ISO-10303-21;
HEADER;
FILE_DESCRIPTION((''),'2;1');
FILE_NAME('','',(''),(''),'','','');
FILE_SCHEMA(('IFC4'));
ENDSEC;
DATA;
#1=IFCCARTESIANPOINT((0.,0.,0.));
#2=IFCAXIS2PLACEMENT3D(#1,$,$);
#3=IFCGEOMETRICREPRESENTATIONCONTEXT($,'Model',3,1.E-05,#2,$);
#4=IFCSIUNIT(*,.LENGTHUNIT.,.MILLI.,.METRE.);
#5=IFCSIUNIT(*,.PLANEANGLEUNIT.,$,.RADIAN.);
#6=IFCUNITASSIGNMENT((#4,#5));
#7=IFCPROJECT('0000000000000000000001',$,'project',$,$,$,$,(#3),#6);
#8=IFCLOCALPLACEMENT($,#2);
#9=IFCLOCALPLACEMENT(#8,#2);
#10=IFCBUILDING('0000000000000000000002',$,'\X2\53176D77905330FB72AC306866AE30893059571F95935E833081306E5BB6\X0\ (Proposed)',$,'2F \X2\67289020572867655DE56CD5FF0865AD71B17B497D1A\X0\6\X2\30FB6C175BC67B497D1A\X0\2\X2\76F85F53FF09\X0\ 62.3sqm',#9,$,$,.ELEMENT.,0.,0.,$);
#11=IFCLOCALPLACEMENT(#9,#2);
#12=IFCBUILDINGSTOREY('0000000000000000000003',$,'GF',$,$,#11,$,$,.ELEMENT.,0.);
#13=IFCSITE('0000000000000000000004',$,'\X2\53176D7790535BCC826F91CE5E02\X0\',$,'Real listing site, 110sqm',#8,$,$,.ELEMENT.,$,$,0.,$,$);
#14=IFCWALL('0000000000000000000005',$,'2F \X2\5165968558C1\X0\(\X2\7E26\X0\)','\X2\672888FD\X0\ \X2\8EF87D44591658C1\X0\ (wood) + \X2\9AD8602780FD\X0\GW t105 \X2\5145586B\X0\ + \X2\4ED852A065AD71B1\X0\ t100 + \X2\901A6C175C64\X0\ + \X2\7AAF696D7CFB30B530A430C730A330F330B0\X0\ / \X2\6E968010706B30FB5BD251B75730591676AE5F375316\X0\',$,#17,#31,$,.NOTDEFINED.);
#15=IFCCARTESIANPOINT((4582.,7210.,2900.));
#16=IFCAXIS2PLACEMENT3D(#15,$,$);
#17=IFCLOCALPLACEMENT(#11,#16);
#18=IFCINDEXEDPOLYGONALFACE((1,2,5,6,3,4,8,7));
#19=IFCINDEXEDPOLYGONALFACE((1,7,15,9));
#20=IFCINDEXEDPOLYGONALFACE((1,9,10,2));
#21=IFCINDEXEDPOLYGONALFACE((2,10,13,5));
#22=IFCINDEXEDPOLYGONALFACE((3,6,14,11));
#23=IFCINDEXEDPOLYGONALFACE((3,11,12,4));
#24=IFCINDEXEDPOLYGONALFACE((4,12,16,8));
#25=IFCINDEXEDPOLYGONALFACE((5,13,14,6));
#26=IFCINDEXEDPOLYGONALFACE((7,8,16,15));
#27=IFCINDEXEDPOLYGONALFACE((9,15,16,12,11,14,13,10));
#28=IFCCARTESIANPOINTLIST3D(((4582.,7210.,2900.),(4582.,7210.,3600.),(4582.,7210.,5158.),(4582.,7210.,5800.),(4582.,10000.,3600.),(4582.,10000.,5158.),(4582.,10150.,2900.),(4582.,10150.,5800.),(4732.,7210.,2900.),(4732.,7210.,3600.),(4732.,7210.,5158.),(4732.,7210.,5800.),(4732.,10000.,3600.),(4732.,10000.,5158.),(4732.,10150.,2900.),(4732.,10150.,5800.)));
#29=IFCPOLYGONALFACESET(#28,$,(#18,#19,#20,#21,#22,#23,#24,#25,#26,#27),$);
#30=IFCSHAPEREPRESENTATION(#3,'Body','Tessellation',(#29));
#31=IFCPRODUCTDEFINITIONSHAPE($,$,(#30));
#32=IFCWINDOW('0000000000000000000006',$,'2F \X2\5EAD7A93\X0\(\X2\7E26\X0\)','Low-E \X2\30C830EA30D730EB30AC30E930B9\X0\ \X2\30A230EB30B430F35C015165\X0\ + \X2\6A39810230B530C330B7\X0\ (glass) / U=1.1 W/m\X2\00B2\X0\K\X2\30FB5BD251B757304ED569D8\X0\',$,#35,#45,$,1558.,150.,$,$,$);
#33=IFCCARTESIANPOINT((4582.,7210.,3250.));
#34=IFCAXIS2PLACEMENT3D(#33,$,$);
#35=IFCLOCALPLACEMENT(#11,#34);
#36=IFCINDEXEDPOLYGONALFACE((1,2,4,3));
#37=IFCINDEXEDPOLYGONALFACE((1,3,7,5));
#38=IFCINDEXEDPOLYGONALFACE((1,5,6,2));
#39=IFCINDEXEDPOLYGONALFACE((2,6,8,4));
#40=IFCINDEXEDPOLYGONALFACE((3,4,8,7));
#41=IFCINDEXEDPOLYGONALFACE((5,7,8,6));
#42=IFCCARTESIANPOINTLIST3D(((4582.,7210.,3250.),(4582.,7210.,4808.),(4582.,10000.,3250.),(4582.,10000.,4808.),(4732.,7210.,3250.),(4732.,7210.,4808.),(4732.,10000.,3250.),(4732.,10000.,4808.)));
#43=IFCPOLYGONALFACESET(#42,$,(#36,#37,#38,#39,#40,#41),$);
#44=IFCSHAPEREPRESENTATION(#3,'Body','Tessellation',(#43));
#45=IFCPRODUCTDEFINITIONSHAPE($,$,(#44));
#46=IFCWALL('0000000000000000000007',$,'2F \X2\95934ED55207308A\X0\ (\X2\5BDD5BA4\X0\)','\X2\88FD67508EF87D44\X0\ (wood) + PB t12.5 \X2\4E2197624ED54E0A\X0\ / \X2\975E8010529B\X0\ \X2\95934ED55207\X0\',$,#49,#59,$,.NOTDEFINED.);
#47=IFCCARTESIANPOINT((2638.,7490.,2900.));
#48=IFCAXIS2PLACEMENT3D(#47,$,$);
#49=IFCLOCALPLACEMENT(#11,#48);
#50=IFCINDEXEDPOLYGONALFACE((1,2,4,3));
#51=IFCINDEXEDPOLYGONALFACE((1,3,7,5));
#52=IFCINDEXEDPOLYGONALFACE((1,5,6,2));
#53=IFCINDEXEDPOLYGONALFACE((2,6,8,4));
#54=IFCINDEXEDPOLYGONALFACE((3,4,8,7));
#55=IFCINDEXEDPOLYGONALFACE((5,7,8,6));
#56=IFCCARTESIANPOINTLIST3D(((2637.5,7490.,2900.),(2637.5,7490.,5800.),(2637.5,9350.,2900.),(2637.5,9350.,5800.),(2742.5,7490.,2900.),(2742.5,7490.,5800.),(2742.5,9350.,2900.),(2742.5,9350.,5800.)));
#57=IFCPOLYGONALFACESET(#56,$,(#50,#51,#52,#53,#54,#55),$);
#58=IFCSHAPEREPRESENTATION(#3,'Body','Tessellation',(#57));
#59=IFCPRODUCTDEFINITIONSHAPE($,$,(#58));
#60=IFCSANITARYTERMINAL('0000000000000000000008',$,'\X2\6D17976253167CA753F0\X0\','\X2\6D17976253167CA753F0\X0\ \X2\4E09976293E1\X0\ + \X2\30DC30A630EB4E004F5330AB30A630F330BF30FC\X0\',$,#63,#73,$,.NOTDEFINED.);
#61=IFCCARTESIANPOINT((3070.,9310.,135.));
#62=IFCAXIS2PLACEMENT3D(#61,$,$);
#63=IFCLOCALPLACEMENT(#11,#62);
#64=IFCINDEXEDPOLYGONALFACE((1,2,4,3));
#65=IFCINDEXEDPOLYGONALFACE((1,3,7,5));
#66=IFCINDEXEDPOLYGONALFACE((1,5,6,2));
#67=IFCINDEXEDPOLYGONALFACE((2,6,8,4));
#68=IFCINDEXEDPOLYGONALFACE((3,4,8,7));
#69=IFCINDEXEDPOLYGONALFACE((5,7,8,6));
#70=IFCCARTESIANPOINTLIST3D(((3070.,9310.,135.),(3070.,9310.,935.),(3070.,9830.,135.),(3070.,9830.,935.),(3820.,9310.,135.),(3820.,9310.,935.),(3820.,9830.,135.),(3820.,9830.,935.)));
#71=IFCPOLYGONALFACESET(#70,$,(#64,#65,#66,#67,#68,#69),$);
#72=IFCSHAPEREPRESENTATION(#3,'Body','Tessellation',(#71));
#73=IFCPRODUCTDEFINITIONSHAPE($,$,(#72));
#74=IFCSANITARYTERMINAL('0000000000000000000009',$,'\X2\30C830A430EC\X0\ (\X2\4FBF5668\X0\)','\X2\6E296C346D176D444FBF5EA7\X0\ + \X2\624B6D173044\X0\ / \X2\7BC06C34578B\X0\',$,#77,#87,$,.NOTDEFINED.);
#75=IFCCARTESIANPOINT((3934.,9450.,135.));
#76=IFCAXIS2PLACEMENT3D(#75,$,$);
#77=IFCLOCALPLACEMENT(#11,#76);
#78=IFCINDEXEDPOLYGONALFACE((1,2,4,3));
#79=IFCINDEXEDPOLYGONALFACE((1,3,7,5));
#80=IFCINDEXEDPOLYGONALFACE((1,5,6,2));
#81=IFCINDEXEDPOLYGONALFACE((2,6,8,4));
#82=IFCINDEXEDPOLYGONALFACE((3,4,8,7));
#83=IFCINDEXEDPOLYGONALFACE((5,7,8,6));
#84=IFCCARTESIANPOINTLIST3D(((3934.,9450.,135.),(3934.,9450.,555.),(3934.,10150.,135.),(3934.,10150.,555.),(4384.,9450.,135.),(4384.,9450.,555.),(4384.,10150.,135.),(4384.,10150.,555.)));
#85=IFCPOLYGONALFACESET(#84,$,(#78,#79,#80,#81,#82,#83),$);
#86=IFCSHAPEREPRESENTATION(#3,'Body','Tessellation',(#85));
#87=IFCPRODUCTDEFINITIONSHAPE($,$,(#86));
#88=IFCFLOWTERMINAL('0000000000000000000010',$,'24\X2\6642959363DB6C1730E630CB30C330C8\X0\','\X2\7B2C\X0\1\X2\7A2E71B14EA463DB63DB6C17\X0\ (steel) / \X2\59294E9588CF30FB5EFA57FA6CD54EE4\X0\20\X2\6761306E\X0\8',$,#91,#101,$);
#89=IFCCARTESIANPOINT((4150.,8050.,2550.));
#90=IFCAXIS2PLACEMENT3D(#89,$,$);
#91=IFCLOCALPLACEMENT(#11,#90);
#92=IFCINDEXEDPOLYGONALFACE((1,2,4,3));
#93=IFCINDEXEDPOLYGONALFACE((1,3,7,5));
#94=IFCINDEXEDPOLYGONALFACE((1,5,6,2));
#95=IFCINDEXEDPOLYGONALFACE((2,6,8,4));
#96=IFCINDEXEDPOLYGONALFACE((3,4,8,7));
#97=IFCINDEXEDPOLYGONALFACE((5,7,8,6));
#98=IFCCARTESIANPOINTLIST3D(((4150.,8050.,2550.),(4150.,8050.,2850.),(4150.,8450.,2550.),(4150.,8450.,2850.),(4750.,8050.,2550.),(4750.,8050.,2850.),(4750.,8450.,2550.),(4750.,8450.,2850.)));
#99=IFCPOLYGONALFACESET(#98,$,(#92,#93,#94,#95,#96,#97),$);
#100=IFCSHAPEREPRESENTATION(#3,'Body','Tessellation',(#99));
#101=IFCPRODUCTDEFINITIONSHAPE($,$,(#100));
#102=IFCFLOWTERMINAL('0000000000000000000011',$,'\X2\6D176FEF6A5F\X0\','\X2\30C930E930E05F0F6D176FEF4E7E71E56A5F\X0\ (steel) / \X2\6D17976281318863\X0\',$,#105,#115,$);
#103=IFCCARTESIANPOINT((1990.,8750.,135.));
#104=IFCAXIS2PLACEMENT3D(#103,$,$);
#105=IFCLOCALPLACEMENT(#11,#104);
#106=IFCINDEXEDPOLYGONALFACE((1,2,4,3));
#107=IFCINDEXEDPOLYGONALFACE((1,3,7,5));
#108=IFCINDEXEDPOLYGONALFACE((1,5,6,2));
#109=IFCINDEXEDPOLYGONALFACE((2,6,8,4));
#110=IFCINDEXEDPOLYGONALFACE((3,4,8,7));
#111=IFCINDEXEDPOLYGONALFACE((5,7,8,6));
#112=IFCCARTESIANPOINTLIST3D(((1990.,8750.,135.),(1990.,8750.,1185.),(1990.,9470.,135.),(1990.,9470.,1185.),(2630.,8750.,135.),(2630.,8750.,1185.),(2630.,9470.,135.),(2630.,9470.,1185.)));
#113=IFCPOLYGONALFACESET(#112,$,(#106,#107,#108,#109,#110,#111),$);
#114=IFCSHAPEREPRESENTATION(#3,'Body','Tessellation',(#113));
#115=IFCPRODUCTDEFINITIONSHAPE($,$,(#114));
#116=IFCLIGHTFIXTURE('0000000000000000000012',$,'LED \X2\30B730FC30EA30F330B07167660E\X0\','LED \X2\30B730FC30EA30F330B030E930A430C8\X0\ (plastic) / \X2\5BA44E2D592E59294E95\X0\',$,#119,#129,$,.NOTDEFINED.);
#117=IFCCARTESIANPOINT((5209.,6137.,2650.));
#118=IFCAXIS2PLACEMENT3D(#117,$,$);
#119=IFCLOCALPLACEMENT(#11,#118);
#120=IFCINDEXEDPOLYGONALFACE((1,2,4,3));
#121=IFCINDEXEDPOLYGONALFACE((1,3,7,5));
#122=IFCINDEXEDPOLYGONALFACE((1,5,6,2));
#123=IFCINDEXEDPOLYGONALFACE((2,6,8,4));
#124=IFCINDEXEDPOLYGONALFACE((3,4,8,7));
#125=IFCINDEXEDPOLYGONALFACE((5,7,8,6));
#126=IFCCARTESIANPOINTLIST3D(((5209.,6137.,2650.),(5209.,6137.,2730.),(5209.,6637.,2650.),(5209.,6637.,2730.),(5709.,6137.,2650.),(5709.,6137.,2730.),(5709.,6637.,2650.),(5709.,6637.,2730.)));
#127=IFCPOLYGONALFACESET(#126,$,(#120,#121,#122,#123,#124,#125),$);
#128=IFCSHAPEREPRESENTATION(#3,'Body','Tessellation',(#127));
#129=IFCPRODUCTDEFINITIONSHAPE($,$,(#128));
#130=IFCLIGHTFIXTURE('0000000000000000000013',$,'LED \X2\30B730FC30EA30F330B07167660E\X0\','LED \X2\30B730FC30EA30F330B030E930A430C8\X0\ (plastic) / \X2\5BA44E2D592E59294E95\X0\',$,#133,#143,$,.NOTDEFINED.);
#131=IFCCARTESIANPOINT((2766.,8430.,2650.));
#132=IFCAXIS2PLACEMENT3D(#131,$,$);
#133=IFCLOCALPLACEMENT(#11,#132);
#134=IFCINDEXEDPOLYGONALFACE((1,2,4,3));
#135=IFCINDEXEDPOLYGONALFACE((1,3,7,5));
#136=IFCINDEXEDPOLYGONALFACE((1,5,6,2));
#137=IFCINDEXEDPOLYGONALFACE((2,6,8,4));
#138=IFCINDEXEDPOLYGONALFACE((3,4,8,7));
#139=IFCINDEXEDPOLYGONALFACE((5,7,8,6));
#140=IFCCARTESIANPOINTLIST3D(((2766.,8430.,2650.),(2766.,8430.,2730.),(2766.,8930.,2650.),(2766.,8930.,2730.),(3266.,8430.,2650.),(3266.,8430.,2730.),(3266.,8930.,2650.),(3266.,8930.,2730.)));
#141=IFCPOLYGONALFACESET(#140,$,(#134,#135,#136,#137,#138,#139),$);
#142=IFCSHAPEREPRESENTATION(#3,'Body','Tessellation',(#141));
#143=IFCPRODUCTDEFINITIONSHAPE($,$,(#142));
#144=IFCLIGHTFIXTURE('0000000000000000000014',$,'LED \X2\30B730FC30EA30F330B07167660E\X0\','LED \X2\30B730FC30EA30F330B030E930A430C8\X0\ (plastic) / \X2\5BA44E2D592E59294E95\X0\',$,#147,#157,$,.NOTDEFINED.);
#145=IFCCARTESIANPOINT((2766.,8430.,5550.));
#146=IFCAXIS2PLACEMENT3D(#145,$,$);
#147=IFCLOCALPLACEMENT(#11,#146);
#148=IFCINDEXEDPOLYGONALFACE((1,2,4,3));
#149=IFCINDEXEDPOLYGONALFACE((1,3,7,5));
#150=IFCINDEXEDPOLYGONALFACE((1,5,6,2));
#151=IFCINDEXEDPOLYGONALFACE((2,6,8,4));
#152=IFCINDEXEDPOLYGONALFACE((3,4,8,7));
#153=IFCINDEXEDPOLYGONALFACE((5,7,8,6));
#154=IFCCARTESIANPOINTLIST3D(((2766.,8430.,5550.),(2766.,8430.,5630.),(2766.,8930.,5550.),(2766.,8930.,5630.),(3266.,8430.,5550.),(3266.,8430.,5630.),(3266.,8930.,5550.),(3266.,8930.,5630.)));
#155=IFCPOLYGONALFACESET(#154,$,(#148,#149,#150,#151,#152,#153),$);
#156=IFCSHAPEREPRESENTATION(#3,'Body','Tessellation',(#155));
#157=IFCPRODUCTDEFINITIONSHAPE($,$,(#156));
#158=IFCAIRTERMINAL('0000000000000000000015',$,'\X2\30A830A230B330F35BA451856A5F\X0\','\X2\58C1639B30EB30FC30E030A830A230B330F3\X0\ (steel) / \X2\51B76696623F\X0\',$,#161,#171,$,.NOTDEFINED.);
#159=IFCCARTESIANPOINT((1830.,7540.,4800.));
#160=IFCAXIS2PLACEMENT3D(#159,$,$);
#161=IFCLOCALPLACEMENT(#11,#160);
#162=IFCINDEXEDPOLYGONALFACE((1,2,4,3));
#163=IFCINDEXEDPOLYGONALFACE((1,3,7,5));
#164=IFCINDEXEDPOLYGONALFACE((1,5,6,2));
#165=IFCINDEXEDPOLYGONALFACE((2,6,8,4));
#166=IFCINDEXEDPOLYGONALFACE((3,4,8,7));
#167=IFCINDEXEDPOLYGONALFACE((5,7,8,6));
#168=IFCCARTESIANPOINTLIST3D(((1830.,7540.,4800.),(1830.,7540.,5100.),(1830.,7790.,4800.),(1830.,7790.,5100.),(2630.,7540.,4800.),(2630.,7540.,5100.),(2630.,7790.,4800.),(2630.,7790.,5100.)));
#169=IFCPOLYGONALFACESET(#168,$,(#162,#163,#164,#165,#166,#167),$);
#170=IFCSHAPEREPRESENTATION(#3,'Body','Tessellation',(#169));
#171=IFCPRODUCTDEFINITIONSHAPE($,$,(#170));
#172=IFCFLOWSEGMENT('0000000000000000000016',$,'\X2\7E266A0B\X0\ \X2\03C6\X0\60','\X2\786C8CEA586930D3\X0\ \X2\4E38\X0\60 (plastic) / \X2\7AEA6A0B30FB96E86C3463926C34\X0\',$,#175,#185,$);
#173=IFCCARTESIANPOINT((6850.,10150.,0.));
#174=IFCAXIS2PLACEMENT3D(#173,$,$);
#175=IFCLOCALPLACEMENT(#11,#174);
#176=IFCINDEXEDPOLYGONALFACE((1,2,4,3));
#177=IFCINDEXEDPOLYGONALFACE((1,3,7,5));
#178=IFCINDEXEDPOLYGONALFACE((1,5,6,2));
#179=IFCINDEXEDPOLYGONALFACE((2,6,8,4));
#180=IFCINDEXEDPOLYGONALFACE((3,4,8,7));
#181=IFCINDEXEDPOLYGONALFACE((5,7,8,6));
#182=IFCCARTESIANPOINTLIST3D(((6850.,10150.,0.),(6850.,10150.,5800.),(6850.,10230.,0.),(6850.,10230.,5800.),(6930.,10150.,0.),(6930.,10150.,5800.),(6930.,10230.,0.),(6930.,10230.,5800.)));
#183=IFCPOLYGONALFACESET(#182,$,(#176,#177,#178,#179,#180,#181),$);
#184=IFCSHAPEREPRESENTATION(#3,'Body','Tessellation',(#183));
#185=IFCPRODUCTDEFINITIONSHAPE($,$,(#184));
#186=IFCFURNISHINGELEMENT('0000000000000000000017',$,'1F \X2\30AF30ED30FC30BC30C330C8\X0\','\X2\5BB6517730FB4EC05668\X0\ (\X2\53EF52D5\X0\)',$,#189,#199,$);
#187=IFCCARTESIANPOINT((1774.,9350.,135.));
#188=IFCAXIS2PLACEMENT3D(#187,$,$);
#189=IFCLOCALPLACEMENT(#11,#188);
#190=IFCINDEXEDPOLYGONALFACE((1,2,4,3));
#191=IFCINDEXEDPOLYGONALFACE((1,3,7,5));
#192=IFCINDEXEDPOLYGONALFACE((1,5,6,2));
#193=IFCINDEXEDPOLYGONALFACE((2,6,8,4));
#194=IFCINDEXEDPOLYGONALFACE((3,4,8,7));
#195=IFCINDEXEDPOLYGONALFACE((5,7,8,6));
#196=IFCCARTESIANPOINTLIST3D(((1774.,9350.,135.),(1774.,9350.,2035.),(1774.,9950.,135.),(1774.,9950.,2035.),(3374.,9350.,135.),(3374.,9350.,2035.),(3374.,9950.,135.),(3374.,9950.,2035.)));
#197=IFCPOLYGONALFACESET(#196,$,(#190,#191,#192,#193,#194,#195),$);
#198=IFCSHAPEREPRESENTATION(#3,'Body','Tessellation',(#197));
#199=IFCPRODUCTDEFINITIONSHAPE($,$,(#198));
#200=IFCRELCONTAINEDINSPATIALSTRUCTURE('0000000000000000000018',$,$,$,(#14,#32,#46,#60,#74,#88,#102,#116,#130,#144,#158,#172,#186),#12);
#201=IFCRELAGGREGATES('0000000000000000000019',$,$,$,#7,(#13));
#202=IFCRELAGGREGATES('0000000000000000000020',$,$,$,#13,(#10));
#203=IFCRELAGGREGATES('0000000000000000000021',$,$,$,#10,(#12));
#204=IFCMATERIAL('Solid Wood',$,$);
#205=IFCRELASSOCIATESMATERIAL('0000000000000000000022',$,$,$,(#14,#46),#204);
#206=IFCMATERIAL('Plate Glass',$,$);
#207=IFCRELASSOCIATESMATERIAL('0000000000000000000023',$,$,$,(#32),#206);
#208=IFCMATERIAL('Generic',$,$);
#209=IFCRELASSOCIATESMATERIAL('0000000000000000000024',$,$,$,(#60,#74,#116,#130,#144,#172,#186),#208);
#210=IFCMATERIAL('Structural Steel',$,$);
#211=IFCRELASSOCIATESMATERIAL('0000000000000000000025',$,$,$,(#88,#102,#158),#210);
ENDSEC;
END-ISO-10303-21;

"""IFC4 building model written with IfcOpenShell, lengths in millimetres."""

from ifc_helpers import new_model, si_unit, frame, frame_2d, origin, place, context, project, spatial, rectangle, extrude, material, element, fill, save


model = new_model("IFC4")

# Units and contexts
model_context = context("Model", 3, precision=1e-05, world=origin())
ifc_project = project(units=[si_unit("LENGTHUNIT", "METRE", prefix="MILLI"), si_unit("PLANEANGLEUNIT", "RADIAN")], contexts=[model_context])

# Site, building, storey
site_placement = place(None, origin())
site = spatial("IfcSite", under=ifc_project, at=site_placement, Name="北海道富良野市", ObjectType="Real listing site, 110sqm", CompositionType="ELEMENT", RefElevation=0.0)
building_placement = place(site_placement, origin())
building = spatial("IfcBuilding", under=site, at=building_placement, Name="北海道・犬と暮らす土間広めの家 (Proposed)", ObjectType="2F 木造在来工法（断熱等級6・気密等級2相当） 62.3sqm", CompositionType="ELEMENT", ElevationOfRefHeight=0.0, ElevationOfTerrain=0.0)
storey_placement = place(building_placement, origin())
storey = spatial("IfcBuildingStorey", under=building, at=storey_placement, Name="GF", CompositionType="ELEMENT", Elevation=0.0)

# Shared definitions
ifc_material_1 = material(Name="Solid Wood")

# Shared definitions
ifc_material_2 = material(Name="Plate Glass")

# Wall, opening, window
wall_1_placement = place(storey_placement, frame((4582.0, 7210.0, 2900.0)))
wall_1 = element("IfcWall", 1, at=wall_1_placement, inside=storey, material=ifc_material_1, Name="2F 入隅壁(縦)", Description="木製 軸組外壁 (wood) + 高性能GW t105 充填 + 付加断熱 t100 + 通気層 + 窯業系サイディング / 準耐火・寒冷地外皮強化", PredefinedType="NOTDEFINED", context=model_context, shape_type="SweptSolid", body=[
    extrude(rectangle(XDim=150.0, YDim=2940.0, at=frame_2d((75.0, 1470.0))), frame((4582.0, 7210.0, 2900.0)), (0.0, 0.0, 1.0), 2900.0),
])
opening_1_placement = place(storey_placement, frame((4582.0, 7210.0, 3250.0)))
opening_1 = element("IfcOpeningElement", 2, at=opening_1_placement, cuts=wall_1, PredefinedType="NOTDEFINED", context=model_context, shape_type="SweptSolid", body=[
    extrude(rectangle(XDim=150.0, YDim=2790.0, at=frame_2d((75.0, 1395.0))), frame((4582.0, 7210.0, 3250.0)), (0.0, 0.0, 1.0), 1558.0),
])
window_1_placement = place(storey_placement, frame((4582.0, 7210.0, 3250.0)))
window_1 = element("IfcWindow", 3, at=window_1_placement, inside=storey, material=ifc_material_2, Name="2F 庭窓(縦)", Description="Low-E トリプルガラス アルゴン封入 + 樹脂サッシ (glass) / U=1.1 W/m²K・寒冷地仕様", OverallHeight=1558.0, OverallWidth=150.0, context=model_context, shape_type="SweptSolid", body=[
    extrude(rectangle(XDim=150.0, YDim=2790.0, at=frame_2d((75.0, 1395.0))), frame((4582.0, 7210.0, 3250.0)), (0.0, 0.0, 1.0), 1558.0),
])
fill(opening_1, window_1)

# Wall
wall_2_placement = place(storey_placement, frame((2638.0, 7490.0, 2900.0)))
element("IfcWall", 4, at=wall_2_placement, inside=storey, material=ifc_material_1, Name="2F 間仕切り (寝室)", Description="製材軸組 (wood) + PB t12.5 両面仕上 / 非耐力 間仕切", PredefinedType="NOTDEFINED", context=model_context, shape_type="SweptSolid", body=[
    extrude(rectangle(XDim=105.0, YDim=1860.0, at=frame_2d((52.0, 930.0))), frame((2638.0, 7490.0, 2900.0)), (0.0, 0.0, 1.0), 2900.0),
])

# Sanitary terminals
ifc_material_3 = material(Name="Generic")
sanitary_terminal_1_placement = place(storey_placement, frame((3070.0, 9310.0, 135.0)))
element("IfcSanitaryTerminal", 5, at=sanitary_terminal_1_placement, inside=storey, material=ifc_material_3, Name="洗面化粧台", Description="洗面化粧台 三面鏡 + ボウル一体カウンター", PredefinedType="NOTDEFINED", context=model_context, shape_type="SweptSolid", body=[
    extrude(rectangle(XDim=750.0, YDim=520.0, at=frame_2d((375.0, 260.0))), frame((3070.0, 9310.0, 135.0)), (0.0, 0.0, 1.0), 800.0),
])
sanitary_terminal_2_placement = place(storey_placement, frame((3934.0, 9450.0, 135.0)))
element("IfcSanitaryTerminal", 6, at=sanitary_terminal_2_placement, inside=storey, material=ifc_material_3, Name="トイレ (便器)", Description="温水洗浄便座 + 手洗い / 節水型", PredefinedType="NOTDEFINED", context=model_context, shape_type="SweptSolid", body=[
    extrude(rectangle(XDim=450.0, YDim=700.0, at=frame_2d((225.0, 350.0))), frame((3934.0, 9450.0, 135.0)), (0.0, 0.0, 1.0), 420.0),
])

# Flow terminals
ifc_material_4 = material(Name="Structural Steel")
flow_terminal_1_placement = place(storey_placement, frame((4150.0, 8050.0, 2550.0)))
element("IfcFlowTerminal", 7, at=flow_terminal_1_placement, inside=storey, material=ifc_material_4, Name="24時間換気ユニット", Description="第1種熱交換換気 (steel) / 天井裏・建基法令20条の8", context=model_context, shape_type="SweptSolid", body=[
    extrude(rectangle(XDim=600.0, YDim=400.0, at=frame_2d((300.0, 200.0))), frame((4150.0, 8050.0, 2550.0)), (0.0, 0.0, 1.0), 300.0),
])
flow_terminal_2_placement = place(storey_placement, frame((1990.0, 8750.0, 135.0)))
element("IfcFlowTerminal", 8, at=flow_terminal_2_placement, inside=storey, material=ifc_material_4, Name="洗濯機", Description="ドラム式洗濯乾燥機 (steel) / 洗面脱衣", context=model_context, shape_type="SweptSolid", body=[
    extrude(rectangle(XDim=640.0, YDim=720.0, at=frame_2d((320.0, 360.0))), frame((1990.0, 8750.0, 135.0)), (0.0, 0.0, 1.0), 1050.0),
])

# Light fixtures
light_fixture_1_placement = place(storey_placement, frame((5209.0, 6137.0, 2650.0)))
element("IfcLightFixture", 9, at=light_fixture_1_placement, inside=storey, material=ifc_material_3, Name="LED シーリング照明", Description="LED シーリングライト (plastic) / 室中央天井", PredefinedType="NOTDEFINED", context=model_context, shape_type="SweptSolid", body=[
    extrude(rectangle(XDim=500.0, YDim=500.0, at=frame_2d((250.0, 250.0))), frame((5209.0, 6137.0, 2650.0)), (0.0, 0.0, 1.0), 80.0),
])
light_fixture_2_placement = place(storey_placement, frame((2766.0, 8430.0, 2650.0)))
element("IfcLightFixture", 10, at=light_fixture_2_placement, inside=storey, material=ifc_material_3, Name="LED シーリング照明", Description="LED シーリングライト (plastic) / 室中央天井", PredefinedType="NOTDEFINED", context=model_context, shape_type="SweptSolid", body=[
    extrude(rectangle(XDim=500.0, YDim=500.0, at=frame_2d((250.0, 250.0))), frame((2766.0, 8430.0, 2650.0)), (0.0, 0.0, 1.0), 80.0),
])
light_fixture_3_placement = place(storey_placement, frame((2766.0, 8430.0, 5550.0)))
element("IfcLightFixture", 11, at=light_fixture_3_placement, inside=storey, material=ifc_material_3, Name="LED シーリング照明", Description="LED シーリングライト (plastic) / 室中央天井", PredefinedType="NOTDEFINED", context=model_context, shape_type="SweptSolid", body=[
    extrude(rectangle(XDim=500.0, YDim=500.0, at=frame_2d((250.0, 250.0))), frame((2766.0, 8430.0, 5550.0)), (0.0, 0.0, 1.0), 80.0),
])

# Air terminal
air_terminal_placement = place(storey_placement, frame((1830.0, 7540.0, 4800.0)))
element("IfcAirTerminal", 12, at=air_terminal_placement, inside=storey, material=ifc_material_4, Name="エアコン室内機", Description="壁掛ルームエアコン (steel) / 冷暖房", PredefinedType="NOTDEFINED", context=model_context, shape_type="SweptSolid", body=[
    extrude(rectangle(XDim=800.0, YDim=250.0, at=frame_2d((400.0, 125.0))), frame((1830.0, 7540.0, 4800.0)), (0.0, 0.0, 1.0), 300.0),
])

# Flow segment
flow_segment_placement = place(storey_placement, frame((6850.0, 10150.0, 0.0)))
element("IfcFlowSegment", 13, at=flow_segment_placement, inside=storey, material=ifc_material_3, Name="縦樋 φ60", Description="硬質塩ビ 丸60 (plastic) / 竪樋・雨水排水", context=model_context, shape_type="SweptSolid", body=[
    extrude(rectangle(XDim=80.0, YDim=80.0, at=frame_2d((40.0, 40.0))), frame((6850.0, 10150.0, 0.0)), (0.0, 0.0, 1.0), 5800.0),
])

# Furnishing element
furnishing_1_placement = place(storey_placement, frame((1774.0, 9350.0, 135.0)))
element("IfcFurnishingElement", 14, at=furnishing_1_placement, inside=storey, material=ifc_material_3, Name="1F クローゼット", Description="家具・什器 (可動)", context=model_context, shape_type="SweptSolid", body=[
    extrude(rectangle(XDim=1600.0, YDim=600.0, at=frame_2d((800.0, 300.0))), frame((1774.0, 9350.0, 135.0)), (0.0, 0.0, 1.0), 1900.0),
])

save(model, "model.ifc")
